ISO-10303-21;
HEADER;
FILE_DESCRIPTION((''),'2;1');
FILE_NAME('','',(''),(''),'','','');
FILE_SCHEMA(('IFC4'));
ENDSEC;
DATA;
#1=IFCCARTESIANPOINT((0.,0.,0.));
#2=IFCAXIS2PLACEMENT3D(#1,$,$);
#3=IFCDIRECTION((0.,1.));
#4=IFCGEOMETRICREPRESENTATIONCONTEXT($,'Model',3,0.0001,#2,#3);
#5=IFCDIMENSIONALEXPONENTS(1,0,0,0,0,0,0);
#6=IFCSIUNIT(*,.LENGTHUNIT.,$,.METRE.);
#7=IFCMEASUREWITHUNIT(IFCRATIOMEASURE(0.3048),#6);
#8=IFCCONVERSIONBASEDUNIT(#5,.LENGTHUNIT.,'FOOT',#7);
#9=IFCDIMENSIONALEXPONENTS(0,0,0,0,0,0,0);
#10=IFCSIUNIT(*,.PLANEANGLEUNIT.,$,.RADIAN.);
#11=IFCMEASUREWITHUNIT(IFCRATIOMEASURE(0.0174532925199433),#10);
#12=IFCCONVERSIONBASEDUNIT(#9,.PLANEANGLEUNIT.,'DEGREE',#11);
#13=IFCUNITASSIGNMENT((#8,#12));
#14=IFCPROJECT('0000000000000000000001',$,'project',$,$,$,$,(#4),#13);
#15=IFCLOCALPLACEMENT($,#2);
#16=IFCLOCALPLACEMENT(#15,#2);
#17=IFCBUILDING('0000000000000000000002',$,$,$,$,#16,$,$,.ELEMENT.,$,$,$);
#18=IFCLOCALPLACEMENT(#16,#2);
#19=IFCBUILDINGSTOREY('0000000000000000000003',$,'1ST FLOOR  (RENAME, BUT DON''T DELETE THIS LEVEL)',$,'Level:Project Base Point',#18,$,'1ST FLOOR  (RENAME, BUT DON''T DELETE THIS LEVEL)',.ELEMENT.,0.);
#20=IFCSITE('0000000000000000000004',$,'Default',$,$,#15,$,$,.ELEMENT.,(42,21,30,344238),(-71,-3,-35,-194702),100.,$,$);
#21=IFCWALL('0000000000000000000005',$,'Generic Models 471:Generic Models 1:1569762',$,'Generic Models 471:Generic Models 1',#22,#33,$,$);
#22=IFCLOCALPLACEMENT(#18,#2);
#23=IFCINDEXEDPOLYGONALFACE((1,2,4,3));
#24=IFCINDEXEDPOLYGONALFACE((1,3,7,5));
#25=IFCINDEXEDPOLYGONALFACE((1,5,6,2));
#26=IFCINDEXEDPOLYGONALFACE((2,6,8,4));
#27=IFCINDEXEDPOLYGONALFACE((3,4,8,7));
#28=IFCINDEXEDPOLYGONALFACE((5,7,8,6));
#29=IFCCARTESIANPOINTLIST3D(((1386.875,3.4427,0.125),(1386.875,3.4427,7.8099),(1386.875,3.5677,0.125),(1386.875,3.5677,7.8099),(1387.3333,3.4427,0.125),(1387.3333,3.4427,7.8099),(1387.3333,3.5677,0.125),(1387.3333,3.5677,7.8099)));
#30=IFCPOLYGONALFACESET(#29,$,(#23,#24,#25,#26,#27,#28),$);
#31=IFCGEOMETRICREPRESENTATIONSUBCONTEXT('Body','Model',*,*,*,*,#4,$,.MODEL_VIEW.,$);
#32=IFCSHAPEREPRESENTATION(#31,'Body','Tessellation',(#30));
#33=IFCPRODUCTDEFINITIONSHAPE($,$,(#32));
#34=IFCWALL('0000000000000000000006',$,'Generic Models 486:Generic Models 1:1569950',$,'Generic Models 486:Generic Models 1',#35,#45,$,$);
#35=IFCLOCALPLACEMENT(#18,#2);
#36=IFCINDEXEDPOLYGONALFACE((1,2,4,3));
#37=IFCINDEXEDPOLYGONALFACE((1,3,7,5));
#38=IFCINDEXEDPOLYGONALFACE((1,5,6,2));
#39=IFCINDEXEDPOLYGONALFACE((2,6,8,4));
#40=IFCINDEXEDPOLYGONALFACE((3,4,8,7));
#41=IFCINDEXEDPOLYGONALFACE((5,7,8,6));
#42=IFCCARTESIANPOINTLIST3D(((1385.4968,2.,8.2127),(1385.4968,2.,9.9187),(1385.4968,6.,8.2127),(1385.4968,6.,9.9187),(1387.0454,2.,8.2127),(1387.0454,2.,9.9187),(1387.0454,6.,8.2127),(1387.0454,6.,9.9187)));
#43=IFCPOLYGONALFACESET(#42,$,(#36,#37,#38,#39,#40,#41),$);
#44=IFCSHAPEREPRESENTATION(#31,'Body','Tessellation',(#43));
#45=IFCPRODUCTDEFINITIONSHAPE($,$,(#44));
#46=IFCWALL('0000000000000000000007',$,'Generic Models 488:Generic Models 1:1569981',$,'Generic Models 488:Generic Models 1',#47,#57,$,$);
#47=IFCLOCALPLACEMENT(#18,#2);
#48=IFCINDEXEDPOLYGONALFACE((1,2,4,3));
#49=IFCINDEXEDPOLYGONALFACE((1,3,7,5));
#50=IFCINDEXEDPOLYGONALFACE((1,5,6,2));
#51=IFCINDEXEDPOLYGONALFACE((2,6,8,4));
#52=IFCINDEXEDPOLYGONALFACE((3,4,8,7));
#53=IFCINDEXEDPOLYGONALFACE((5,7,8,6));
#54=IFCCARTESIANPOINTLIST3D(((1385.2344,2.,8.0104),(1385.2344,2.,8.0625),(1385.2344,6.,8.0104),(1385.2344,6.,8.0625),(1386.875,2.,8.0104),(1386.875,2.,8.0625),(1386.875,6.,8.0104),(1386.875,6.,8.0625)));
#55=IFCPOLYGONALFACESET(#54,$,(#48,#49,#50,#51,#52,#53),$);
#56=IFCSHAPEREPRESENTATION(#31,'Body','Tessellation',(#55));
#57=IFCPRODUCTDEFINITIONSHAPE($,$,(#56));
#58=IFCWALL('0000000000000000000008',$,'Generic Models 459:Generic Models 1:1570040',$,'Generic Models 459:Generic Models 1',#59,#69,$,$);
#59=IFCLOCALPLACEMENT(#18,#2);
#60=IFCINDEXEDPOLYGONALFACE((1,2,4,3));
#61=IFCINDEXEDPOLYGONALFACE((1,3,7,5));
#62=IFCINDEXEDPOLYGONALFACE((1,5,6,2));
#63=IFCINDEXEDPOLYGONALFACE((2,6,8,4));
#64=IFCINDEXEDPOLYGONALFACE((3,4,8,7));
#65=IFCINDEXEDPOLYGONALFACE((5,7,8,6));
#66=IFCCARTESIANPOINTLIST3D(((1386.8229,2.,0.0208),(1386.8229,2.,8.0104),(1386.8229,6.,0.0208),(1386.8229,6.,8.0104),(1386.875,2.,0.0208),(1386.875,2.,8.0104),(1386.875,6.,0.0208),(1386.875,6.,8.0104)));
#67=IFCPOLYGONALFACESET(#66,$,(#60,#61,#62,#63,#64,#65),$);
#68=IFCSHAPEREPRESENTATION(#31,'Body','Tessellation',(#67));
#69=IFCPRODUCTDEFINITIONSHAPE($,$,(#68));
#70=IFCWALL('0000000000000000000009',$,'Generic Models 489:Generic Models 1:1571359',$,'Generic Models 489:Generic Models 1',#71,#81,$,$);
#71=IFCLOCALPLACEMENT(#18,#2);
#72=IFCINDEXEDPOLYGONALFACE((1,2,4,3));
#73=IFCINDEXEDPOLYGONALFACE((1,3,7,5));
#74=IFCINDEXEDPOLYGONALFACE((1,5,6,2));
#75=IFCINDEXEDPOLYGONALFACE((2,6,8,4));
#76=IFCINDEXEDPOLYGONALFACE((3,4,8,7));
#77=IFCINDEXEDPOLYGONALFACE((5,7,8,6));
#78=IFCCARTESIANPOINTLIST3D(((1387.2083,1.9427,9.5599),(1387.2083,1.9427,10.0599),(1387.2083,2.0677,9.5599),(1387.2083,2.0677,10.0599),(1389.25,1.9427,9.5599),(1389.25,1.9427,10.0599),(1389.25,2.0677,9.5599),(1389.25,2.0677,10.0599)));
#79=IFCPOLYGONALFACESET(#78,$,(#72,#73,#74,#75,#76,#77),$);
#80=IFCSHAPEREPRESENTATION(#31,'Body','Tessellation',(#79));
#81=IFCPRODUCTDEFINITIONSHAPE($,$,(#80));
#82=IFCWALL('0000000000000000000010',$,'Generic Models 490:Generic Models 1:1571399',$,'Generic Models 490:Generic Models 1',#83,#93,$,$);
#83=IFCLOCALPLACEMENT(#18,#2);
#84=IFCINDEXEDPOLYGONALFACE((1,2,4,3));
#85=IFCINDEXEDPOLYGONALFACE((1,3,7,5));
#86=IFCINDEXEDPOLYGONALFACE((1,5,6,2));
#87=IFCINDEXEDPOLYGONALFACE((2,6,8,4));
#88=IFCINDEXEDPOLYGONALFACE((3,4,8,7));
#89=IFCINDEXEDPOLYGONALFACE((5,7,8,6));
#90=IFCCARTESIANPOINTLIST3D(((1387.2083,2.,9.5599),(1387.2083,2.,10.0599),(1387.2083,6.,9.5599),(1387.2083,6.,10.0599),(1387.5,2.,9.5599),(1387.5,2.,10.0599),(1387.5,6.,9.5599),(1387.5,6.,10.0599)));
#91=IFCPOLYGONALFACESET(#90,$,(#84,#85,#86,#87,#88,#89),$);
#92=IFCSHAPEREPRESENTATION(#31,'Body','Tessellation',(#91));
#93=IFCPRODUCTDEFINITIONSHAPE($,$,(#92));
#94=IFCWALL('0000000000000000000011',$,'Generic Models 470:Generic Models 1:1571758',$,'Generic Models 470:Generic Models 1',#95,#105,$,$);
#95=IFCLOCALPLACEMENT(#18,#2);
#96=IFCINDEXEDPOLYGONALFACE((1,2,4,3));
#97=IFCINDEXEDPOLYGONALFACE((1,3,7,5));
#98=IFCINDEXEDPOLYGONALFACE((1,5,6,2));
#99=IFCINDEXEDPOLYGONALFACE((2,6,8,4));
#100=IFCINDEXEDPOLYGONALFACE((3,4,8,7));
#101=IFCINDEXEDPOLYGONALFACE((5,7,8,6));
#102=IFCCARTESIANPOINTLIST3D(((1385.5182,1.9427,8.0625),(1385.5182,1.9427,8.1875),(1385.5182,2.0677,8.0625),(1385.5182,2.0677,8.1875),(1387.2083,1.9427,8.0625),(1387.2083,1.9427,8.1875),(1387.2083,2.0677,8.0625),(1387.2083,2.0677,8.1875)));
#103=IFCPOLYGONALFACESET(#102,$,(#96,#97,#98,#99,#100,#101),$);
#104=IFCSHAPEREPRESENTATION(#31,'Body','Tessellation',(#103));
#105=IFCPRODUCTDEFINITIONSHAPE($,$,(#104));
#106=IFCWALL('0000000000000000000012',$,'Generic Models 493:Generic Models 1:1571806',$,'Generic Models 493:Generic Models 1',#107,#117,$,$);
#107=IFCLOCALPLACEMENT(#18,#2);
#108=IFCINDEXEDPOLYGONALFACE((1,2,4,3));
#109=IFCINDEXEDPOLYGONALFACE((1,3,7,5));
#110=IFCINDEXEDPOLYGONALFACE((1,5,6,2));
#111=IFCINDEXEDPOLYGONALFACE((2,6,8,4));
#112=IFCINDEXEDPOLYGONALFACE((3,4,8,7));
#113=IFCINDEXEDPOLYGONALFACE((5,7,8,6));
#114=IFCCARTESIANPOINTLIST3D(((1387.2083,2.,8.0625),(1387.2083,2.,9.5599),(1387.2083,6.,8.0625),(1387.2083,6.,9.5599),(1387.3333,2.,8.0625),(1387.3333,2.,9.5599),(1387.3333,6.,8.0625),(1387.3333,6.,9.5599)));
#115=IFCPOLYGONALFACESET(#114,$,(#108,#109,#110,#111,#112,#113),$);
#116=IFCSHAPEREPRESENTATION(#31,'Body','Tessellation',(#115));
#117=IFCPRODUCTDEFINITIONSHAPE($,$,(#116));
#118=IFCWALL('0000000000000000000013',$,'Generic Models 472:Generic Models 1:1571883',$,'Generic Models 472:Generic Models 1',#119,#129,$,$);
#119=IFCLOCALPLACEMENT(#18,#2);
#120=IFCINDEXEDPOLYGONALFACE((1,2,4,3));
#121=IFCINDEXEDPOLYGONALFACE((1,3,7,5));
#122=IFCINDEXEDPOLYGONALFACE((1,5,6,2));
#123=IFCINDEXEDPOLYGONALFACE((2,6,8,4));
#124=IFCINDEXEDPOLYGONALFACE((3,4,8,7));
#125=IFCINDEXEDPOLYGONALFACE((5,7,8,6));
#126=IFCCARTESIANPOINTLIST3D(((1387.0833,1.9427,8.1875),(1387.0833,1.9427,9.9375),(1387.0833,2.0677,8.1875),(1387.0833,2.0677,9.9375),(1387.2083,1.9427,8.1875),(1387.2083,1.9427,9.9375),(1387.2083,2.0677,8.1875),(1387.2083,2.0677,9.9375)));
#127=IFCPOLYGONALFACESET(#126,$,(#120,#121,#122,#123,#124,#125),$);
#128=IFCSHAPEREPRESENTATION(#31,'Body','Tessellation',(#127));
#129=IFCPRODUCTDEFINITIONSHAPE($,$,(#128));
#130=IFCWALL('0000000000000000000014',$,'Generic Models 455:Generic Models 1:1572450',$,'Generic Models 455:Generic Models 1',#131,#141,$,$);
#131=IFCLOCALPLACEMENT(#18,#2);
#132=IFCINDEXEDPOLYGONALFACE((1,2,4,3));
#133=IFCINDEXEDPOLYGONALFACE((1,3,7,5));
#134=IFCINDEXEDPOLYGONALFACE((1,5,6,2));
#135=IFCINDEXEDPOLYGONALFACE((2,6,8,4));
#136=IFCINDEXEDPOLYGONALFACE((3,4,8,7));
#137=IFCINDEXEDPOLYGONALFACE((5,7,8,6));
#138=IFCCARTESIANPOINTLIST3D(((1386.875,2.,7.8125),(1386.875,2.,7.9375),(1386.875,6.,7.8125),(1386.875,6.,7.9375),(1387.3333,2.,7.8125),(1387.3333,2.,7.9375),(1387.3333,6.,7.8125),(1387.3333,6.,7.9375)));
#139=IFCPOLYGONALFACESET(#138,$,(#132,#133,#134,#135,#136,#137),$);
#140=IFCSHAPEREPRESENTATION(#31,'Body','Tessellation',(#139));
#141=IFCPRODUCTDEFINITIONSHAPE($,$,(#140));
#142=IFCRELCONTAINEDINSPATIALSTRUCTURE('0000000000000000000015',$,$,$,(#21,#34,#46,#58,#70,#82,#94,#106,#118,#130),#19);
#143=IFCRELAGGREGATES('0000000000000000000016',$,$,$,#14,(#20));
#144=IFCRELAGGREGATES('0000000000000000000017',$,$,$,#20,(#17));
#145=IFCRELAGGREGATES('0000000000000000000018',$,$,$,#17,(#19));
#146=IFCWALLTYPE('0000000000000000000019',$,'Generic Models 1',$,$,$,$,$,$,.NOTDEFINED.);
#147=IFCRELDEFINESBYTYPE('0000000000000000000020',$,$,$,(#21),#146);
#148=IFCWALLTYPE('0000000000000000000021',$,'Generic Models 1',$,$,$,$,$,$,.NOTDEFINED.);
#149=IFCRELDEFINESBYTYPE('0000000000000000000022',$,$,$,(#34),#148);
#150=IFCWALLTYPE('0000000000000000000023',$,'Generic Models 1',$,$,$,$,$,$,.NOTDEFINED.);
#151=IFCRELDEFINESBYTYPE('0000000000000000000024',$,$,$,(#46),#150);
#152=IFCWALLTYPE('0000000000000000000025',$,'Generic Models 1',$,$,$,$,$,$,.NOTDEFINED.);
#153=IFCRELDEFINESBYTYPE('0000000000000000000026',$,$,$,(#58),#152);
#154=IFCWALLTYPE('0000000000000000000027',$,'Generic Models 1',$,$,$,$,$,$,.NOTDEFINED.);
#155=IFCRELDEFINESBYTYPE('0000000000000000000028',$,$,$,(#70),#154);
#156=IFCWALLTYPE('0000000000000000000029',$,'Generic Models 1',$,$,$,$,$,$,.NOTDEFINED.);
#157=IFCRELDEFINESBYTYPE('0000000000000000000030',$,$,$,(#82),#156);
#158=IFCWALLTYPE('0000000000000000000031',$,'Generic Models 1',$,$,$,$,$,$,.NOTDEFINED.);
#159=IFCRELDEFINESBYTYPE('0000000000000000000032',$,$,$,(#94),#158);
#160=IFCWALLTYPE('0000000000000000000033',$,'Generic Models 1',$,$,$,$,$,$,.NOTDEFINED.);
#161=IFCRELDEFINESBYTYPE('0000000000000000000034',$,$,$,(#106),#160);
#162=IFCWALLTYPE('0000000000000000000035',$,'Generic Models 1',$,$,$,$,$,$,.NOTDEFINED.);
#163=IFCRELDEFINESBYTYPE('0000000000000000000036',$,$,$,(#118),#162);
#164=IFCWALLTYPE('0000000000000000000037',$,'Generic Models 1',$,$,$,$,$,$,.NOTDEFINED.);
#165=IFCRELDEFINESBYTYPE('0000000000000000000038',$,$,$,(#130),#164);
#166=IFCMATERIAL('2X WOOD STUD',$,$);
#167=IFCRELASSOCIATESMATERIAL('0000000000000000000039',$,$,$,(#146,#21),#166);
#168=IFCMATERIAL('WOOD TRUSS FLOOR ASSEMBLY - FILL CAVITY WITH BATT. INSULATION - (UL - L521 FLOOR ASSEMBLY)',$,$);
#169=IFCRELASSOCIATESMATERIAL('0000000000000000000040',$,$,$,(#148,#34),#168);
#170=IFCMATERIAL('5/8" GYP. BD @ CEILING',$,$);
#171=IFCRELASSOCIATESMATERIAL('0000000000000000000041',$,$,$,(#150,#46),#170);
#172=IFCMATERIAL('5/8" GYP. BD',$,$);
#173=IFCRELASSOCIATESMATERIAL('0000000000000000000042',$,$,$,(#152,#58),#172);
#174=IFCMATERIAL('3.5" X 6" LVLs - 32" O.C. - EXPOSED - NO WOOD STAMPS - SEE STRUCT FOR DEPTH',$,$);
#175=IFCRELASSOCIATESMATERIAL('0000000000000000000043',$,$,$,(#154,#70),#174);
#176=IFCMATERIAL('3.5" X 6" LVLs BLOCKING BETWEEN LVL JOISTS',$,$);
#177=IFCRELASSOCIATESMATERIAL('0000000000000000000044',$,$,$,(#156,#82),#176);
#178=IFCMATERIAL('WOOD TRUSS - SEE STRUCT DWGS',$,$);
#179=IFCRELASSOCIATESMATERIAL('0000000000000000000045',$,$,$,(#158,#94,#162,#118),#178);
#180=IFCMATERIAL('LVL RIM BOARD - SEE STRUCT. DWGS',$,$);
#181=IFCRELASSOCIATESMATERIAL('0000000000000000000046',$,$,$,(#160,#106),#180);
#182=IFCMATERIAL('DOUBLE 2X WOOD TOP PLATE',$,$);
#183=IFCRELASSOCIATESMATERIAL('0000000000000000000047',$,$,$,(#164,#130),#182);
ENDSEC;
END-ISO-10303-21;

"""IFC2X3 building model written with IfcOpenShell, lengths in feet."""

from ifc_helpers import new_model, entity, si_unit, converted_unit, direction, frame, frame_2d, origin, place, context, subcontext, project, spatial, rectangle, extrude, material, type_object, element, save


model = new_model("IFC2X3")

# Units and contexts
model_context = context("Model", 3, precision=0.0001, world=origin(), true_north=direction((0.0, 1.0)))
body_context = subcontext(model_context, "Body", "Model", "MODEL_VIEW")
ifc_project = project(units=[converted_unit("LENGTHUNIT", "FOOT", entity("IfcRatioMeasure", 0.3048), si_unit("LENGTHUNIT", "METRE"), dimensions=[1, 0, 0, 0, 0, 0, 0]), converted_unit("PLANEANGLEUNIT", "DEGREE", entity("IfcRatioMeasure", 0.0174532925199433), si_unit("PLANEANGLEUNIT", "RADIAN"), dimensions=[0, 0, 0, 0, 0, 0, 0])], contexts=[model_context])

# Site, building, storey
site_placement = place(None, origin())
site = spatial("IfcSite", under=ifc_project, at=site_placement, Name="Default", CompositionType="ELEMENT", RefLatitude=(42, 21, 30, 344238), RefLongitude=(-71, -3, -35, -194702), RefElevation=100.0)
building_placement = place(site_placement, origin())
building = spatial("IfcBuilding", under=site, at=building_placement, CompositionType="ELEMENT")
storey_placement = place(building_placement, origin())
storey = spatial("IfcBuildingStorey", under=building, at=storey_placement, Name="1ST FLOOR  (RENAME, BUT DON'T DELETE THIS LEVEL)", ObjectType="Level:Project Base Point", LongName="1ST FLOOR  (RENAME, BUT DON'T DELETE THIS LEVEL)", CompositionType="ELEMENT", Elevation=0.0)

# Walls
ifc_material_1 = material(Name="5/8\" GYP. BD")
ifc_material_2 = material(Name="DOUBLE 2X WOOD TOP PLATE")
ifc_material_3 = material(Name="2X WOOD STUD")
ifc_material_4 = material(Name="5/8\" GYP. BD @ CEILING")
ifc_material_5 = material(Name="WOOD TRUSS - SEE STRUCT DWGS")
wall_type_1 = type_object("IfcWallType", Name="Generic Models 1", PredefinedType="NOTDEFINED", material=ifc_material_3)
wall_1_placement = place(storey_placement, frame((1386.875, 3.4427, 0.125)))
element("IfcWall", 1, at=wall_1_placement, inside=storey, type_object=wall_type_1, material=ifc_material_3, Name="Generic Models 471:Generic Models 1:1569762", ObjectType="Generic Models 471:Generic Models 1", context=body_context, shape_type="SweptSolid", body=[
    extrude(rectangle(XDim=0.125, YDim=0.4583, at=frame_2d((0.0, 0.0), x_axis=(1.0, 0.0))), frame((0.2292, 0.0625, 0.0), z_axis=(0.0, 0.0, 1.0), x_axis=(0.0, 1.0, 0.0)), (0.0, 0.0, 1.0), 7.6849),
])
ifc_material_6 = material(Name="WOOD TRUSS FLOOR ASSEMBLY - FILL CAVITY WITH BATT. INSULATION - (UL - L521 FLOOR ASSEMBLY)")
wall_type_2 = type_object("IfcWallType", Name="Generic Models 1", PredefinedType="NOTDEFINED", material=ifc_material_6)
wall_2_placement = place(storey_placement, frame((1385.4968, 2.0, 8.2127), z_axis=(0.0, 0.0, 1.0), x_axis=(0.0, 1.0, 0.0)))
element("IfcWall", 2, at=wall_2_placement, inside=storey, type_object=wall_type_2, material=ifc_material_6, Name="Generic Models 486:Generic Models 1:1569950", ObjectType="Generic Models 486:Generic Models 1", context=body_context, shape_type="SweptSolid", body=[
    extrude(rectangle(XDim=4.0, YDim=1.5487, at=frame_2d((0.0, 0.0), x_axis=(1.0, 0.0))), frame((2.0, -0.7743, 0.0)), (0.0, 0.0, 1.0), 1.706),
])
wall_type_3 = type_object("IfcWallType", Name="Generic Models 1", PredefinedType="NOTDEFINED", material=ifc_material_4)
wall_3_placement = place(storey_placement, frame((1385.2344, 2.0, 8.0104), z_axis=(0.0, 0.0, 1.0), x_axis=(0.0, 1.0, 0.0)))
element("IfcWall", 3, at=wall_3_placement, inside=storey, type_object=wall_type_3, material=ifc_material_4, Name="Generic Models 488:Generic Models 1:1569981", ObjectType="Generic Models 488:Generic Models 1", context=body_context, shape_type="SweptSolid", body=[
    extrude(rectangle(XDim=4.0, YDim=1.6406, at=frame_2d((0.0, 0.0), x_axis=(1.0, 0.0))), frame((2.0, -0.8203, 0.0)), (0.0, 0.0, 1.0), 0.0521),
])
wall_type_4 = type_object("IfcWallType", Name="Generic Models 1", PredefinedType="NOTDEFINED", material=ifc_material_1)
wall_4_placement = place(storey_placement, frame((1386.8229, 2.0, 0.0208), z_axis=(0.0, 0.0, 1.0), x_axis=(0.0, 1.0, 0.0)))
element("IfcWall", 4, at=wall_4_placement, inside=storey, type_object=wall_type_4, material=ifc_material_1, Name="Generic Models 459:Generic Models 1:1570040", ObjectType="Generic Models 459:Generic Models 1", context=body_context, shape_type="SweptSolid", body=[
    extrude(rectangle(XDim=4.0, YDim=0.0521, at=frame_2d((0.0, 0.0), x_axis=(1.0, 0.0))), frame((2.0, -0.026, 0.0)), (0.0, 0.0, 1.0), 7.9896),
])
ifc_material_7 = material(Name="3.5\" X 6\" LVLs - 32\" O.C. - EXPOSED - NO WOOD STAMPS - SEE STRUCT FOR DEPTH")
wall_type_5 = type_object("IfcWallType", Name="Generic Models 1", PredefinedType="NOTDEFINED", material=ifc_material_7)
wall_5_placement = place(storey_placement, frame((1387.2083, 1.9427, 9.5599)))
element("IfcWall", 5, at=wall_5_placement, inside=storey, type_object=wall_type_5, material=ifc_material_7, Name="Generic Models 489:Generic Models 1:1571359", ObjectType="Generic Models 489:Generic Models 1", context=body_context, shape_type="SweptSolid", body=[
    extrude(rectangle(XDim=0.125, YDim=2.0417, at=frame_2d((0.0, 0.0), x_axis=(1.0, 0.0))), frame((1.0208, 0.0625, 0.0), z_axis=(0.0, 0.0, 1.0), x_axis=(0.0, 1.0, 0.0)), (0.0, 0.0, 1.0), 0.5),
])
ifc_material_8 = material(Name="3.5\" X 6\" LVLs BLOCKING BETWEEN LVL JOISTS")
wall_type_6 = type_object("IfcWallType", Name="Generic Models 1", PredefinedType="NOTDEFINED", material=ifc_material_8)
wall_6_placement = place(storey_placement, frame((1387.2083, 2.0, 9.5599), z_axis=(0.0, 0.0, 1.0), x_axis=(0.0, 1.0, 0.0)))
element("IfcWall", 6, at=wall_6_placement, inside=storey, type_object=wall_type_6, material=ifc_material_8, Name="Generic Models 490:Generic Models 1:1571399", ObjectType="Generic Models 490:Generic Models 1", context=body_context, shape_type="SweptSolid", body=[
    extrude(rectangle(XDim=4.0, YDim=0.2917, at=frame_2d((0.0, 0.0), x_axis=(1.0, 0.0))), frame((2.0, -0.1458, 0.0)), (0.0, 0.0, 1.0), 0.5),
])
wall_type_7 = type_object("IfcWallType", Name="Generic Models 1", PredefinedType="NOTDEFINED", material=ifc_material_5)
wall_7_placement = place(storey_placement, frame((1385.5182, 1.9427, 8.0625)))
element("IfcWall", 7, at=wall_7_placement, inside=storey, type_object=wall_type_7, material=ifc_material_5, Name="Generic Models 470:Generic Models 1:1571758", ObjectType="Generic Models 470:Generic Models 1", context=body_context, shape_type="SweptSolid", body=[
    extrude(rectangle(XDim=0.125, YDim=1.6902, at=frame_2d((0.0, 0.0), x_axis=(1.0, 0.0))), frame((0.8451, 0.0625, 0.0), z_axis=(0.0, 0.0, 1.0), x_axis=(0.0, 1.0, 0.0)), (0.0, 0.0, 1.0), 0.125),
])
ifc_material_9 = material(Name="LVL RIM BOARD - SEE STRUCT. DWGS")
wall_type_8 = type_object("IfcWallType", Name="Generic Models 1", PredefinedType="NOTDEFINED", material=ifc_material_9)
wall_8_placement = place(storey_placement, frame((1387.2083, 2.0, 8.0625), z_axis=(0.0, 0.0, 1.0), x_axis=(0.0, 1.0, 0.0)))
element("IfcWall", 8, at=wall_8_placement, inside=storey, type_object=wall_type_8, material=ifc_material_9, Name="Generic Models 493:Generic Models 1:1571806", ObjectType="Generic Models 493:Generic Models 1", context=body_context, shape_type="SweptSolid", body=[
    extrude(rectangle(XDim=4.0, YDim=0.125, at=frame_2d((0.0, 0.0), x_axis=(1.0, 0.0))), frame((2.0, -0.0625, 0.0)), (0.0, 0.0, 1.0), 1.4974),
])
wall_type_9 = type_object("IfcWallType", Name="Generic Models 1", PredefinedType="NOTDEFINED", material=ifc_material_5)
wall_9_placement = place(storey_placement, frame((1387.0833, 1.9427, 8.1875), z_axis=(0.0, 0.0, 1.0), x_axis=(0.0, 1.0, 0.0)))
element("IfcWall", 9, at=wall_9_placement, inside=storey, type_object=wall_type_9, material=ifc_material_5, Name="Generic Models 472:Generic Models 1:1571883", ObjectType="Generic Models 472:Generic Models 1", context=body_context, shape_type="SweptSolid", body=[
    extrude(rectangle(XDim=0.125, YDim=0.125, at=frame_2d((0.0, 0.0), x_axis=(1.0, 0.0))), frame((0.0625, -0.0625, 0.0)), (0.0, 0.0, 1.0), 1.75),
])
wall_type_10 = type_object("IfcWallType", Name="Generic Models 1", PredefinedType="NOTDEFINED", material=ifc_material_2)
wall_10_placement = place(storey_placement, frame((1386.875, 2.0, 7.8125), z_axis=(0.0, 0.0, 1.0), x_axis=(0.0, 1.0, 0.0)))
element("IfcWall", 10, at=wall_10_placement, inside=storey, type_object=wall_type_10, material=ifc_material_2, Name="Generic Models 455:Generic Models 1:1572450", ObjectType="Generic Models 455:Generic Models 1", context=body_context, shape_type="SweptSolid", body=[
    extrude(rectangle(XDim=4.0, YDim=0.4583, at=frame_2d((0.0, 0.0), x_axis=(1.0, 0.0))), frame((2.0, -0.2292, 0.0)), (0.0, 0.0, 1.0), 0.125),
])

save(model, "model.ifc")
